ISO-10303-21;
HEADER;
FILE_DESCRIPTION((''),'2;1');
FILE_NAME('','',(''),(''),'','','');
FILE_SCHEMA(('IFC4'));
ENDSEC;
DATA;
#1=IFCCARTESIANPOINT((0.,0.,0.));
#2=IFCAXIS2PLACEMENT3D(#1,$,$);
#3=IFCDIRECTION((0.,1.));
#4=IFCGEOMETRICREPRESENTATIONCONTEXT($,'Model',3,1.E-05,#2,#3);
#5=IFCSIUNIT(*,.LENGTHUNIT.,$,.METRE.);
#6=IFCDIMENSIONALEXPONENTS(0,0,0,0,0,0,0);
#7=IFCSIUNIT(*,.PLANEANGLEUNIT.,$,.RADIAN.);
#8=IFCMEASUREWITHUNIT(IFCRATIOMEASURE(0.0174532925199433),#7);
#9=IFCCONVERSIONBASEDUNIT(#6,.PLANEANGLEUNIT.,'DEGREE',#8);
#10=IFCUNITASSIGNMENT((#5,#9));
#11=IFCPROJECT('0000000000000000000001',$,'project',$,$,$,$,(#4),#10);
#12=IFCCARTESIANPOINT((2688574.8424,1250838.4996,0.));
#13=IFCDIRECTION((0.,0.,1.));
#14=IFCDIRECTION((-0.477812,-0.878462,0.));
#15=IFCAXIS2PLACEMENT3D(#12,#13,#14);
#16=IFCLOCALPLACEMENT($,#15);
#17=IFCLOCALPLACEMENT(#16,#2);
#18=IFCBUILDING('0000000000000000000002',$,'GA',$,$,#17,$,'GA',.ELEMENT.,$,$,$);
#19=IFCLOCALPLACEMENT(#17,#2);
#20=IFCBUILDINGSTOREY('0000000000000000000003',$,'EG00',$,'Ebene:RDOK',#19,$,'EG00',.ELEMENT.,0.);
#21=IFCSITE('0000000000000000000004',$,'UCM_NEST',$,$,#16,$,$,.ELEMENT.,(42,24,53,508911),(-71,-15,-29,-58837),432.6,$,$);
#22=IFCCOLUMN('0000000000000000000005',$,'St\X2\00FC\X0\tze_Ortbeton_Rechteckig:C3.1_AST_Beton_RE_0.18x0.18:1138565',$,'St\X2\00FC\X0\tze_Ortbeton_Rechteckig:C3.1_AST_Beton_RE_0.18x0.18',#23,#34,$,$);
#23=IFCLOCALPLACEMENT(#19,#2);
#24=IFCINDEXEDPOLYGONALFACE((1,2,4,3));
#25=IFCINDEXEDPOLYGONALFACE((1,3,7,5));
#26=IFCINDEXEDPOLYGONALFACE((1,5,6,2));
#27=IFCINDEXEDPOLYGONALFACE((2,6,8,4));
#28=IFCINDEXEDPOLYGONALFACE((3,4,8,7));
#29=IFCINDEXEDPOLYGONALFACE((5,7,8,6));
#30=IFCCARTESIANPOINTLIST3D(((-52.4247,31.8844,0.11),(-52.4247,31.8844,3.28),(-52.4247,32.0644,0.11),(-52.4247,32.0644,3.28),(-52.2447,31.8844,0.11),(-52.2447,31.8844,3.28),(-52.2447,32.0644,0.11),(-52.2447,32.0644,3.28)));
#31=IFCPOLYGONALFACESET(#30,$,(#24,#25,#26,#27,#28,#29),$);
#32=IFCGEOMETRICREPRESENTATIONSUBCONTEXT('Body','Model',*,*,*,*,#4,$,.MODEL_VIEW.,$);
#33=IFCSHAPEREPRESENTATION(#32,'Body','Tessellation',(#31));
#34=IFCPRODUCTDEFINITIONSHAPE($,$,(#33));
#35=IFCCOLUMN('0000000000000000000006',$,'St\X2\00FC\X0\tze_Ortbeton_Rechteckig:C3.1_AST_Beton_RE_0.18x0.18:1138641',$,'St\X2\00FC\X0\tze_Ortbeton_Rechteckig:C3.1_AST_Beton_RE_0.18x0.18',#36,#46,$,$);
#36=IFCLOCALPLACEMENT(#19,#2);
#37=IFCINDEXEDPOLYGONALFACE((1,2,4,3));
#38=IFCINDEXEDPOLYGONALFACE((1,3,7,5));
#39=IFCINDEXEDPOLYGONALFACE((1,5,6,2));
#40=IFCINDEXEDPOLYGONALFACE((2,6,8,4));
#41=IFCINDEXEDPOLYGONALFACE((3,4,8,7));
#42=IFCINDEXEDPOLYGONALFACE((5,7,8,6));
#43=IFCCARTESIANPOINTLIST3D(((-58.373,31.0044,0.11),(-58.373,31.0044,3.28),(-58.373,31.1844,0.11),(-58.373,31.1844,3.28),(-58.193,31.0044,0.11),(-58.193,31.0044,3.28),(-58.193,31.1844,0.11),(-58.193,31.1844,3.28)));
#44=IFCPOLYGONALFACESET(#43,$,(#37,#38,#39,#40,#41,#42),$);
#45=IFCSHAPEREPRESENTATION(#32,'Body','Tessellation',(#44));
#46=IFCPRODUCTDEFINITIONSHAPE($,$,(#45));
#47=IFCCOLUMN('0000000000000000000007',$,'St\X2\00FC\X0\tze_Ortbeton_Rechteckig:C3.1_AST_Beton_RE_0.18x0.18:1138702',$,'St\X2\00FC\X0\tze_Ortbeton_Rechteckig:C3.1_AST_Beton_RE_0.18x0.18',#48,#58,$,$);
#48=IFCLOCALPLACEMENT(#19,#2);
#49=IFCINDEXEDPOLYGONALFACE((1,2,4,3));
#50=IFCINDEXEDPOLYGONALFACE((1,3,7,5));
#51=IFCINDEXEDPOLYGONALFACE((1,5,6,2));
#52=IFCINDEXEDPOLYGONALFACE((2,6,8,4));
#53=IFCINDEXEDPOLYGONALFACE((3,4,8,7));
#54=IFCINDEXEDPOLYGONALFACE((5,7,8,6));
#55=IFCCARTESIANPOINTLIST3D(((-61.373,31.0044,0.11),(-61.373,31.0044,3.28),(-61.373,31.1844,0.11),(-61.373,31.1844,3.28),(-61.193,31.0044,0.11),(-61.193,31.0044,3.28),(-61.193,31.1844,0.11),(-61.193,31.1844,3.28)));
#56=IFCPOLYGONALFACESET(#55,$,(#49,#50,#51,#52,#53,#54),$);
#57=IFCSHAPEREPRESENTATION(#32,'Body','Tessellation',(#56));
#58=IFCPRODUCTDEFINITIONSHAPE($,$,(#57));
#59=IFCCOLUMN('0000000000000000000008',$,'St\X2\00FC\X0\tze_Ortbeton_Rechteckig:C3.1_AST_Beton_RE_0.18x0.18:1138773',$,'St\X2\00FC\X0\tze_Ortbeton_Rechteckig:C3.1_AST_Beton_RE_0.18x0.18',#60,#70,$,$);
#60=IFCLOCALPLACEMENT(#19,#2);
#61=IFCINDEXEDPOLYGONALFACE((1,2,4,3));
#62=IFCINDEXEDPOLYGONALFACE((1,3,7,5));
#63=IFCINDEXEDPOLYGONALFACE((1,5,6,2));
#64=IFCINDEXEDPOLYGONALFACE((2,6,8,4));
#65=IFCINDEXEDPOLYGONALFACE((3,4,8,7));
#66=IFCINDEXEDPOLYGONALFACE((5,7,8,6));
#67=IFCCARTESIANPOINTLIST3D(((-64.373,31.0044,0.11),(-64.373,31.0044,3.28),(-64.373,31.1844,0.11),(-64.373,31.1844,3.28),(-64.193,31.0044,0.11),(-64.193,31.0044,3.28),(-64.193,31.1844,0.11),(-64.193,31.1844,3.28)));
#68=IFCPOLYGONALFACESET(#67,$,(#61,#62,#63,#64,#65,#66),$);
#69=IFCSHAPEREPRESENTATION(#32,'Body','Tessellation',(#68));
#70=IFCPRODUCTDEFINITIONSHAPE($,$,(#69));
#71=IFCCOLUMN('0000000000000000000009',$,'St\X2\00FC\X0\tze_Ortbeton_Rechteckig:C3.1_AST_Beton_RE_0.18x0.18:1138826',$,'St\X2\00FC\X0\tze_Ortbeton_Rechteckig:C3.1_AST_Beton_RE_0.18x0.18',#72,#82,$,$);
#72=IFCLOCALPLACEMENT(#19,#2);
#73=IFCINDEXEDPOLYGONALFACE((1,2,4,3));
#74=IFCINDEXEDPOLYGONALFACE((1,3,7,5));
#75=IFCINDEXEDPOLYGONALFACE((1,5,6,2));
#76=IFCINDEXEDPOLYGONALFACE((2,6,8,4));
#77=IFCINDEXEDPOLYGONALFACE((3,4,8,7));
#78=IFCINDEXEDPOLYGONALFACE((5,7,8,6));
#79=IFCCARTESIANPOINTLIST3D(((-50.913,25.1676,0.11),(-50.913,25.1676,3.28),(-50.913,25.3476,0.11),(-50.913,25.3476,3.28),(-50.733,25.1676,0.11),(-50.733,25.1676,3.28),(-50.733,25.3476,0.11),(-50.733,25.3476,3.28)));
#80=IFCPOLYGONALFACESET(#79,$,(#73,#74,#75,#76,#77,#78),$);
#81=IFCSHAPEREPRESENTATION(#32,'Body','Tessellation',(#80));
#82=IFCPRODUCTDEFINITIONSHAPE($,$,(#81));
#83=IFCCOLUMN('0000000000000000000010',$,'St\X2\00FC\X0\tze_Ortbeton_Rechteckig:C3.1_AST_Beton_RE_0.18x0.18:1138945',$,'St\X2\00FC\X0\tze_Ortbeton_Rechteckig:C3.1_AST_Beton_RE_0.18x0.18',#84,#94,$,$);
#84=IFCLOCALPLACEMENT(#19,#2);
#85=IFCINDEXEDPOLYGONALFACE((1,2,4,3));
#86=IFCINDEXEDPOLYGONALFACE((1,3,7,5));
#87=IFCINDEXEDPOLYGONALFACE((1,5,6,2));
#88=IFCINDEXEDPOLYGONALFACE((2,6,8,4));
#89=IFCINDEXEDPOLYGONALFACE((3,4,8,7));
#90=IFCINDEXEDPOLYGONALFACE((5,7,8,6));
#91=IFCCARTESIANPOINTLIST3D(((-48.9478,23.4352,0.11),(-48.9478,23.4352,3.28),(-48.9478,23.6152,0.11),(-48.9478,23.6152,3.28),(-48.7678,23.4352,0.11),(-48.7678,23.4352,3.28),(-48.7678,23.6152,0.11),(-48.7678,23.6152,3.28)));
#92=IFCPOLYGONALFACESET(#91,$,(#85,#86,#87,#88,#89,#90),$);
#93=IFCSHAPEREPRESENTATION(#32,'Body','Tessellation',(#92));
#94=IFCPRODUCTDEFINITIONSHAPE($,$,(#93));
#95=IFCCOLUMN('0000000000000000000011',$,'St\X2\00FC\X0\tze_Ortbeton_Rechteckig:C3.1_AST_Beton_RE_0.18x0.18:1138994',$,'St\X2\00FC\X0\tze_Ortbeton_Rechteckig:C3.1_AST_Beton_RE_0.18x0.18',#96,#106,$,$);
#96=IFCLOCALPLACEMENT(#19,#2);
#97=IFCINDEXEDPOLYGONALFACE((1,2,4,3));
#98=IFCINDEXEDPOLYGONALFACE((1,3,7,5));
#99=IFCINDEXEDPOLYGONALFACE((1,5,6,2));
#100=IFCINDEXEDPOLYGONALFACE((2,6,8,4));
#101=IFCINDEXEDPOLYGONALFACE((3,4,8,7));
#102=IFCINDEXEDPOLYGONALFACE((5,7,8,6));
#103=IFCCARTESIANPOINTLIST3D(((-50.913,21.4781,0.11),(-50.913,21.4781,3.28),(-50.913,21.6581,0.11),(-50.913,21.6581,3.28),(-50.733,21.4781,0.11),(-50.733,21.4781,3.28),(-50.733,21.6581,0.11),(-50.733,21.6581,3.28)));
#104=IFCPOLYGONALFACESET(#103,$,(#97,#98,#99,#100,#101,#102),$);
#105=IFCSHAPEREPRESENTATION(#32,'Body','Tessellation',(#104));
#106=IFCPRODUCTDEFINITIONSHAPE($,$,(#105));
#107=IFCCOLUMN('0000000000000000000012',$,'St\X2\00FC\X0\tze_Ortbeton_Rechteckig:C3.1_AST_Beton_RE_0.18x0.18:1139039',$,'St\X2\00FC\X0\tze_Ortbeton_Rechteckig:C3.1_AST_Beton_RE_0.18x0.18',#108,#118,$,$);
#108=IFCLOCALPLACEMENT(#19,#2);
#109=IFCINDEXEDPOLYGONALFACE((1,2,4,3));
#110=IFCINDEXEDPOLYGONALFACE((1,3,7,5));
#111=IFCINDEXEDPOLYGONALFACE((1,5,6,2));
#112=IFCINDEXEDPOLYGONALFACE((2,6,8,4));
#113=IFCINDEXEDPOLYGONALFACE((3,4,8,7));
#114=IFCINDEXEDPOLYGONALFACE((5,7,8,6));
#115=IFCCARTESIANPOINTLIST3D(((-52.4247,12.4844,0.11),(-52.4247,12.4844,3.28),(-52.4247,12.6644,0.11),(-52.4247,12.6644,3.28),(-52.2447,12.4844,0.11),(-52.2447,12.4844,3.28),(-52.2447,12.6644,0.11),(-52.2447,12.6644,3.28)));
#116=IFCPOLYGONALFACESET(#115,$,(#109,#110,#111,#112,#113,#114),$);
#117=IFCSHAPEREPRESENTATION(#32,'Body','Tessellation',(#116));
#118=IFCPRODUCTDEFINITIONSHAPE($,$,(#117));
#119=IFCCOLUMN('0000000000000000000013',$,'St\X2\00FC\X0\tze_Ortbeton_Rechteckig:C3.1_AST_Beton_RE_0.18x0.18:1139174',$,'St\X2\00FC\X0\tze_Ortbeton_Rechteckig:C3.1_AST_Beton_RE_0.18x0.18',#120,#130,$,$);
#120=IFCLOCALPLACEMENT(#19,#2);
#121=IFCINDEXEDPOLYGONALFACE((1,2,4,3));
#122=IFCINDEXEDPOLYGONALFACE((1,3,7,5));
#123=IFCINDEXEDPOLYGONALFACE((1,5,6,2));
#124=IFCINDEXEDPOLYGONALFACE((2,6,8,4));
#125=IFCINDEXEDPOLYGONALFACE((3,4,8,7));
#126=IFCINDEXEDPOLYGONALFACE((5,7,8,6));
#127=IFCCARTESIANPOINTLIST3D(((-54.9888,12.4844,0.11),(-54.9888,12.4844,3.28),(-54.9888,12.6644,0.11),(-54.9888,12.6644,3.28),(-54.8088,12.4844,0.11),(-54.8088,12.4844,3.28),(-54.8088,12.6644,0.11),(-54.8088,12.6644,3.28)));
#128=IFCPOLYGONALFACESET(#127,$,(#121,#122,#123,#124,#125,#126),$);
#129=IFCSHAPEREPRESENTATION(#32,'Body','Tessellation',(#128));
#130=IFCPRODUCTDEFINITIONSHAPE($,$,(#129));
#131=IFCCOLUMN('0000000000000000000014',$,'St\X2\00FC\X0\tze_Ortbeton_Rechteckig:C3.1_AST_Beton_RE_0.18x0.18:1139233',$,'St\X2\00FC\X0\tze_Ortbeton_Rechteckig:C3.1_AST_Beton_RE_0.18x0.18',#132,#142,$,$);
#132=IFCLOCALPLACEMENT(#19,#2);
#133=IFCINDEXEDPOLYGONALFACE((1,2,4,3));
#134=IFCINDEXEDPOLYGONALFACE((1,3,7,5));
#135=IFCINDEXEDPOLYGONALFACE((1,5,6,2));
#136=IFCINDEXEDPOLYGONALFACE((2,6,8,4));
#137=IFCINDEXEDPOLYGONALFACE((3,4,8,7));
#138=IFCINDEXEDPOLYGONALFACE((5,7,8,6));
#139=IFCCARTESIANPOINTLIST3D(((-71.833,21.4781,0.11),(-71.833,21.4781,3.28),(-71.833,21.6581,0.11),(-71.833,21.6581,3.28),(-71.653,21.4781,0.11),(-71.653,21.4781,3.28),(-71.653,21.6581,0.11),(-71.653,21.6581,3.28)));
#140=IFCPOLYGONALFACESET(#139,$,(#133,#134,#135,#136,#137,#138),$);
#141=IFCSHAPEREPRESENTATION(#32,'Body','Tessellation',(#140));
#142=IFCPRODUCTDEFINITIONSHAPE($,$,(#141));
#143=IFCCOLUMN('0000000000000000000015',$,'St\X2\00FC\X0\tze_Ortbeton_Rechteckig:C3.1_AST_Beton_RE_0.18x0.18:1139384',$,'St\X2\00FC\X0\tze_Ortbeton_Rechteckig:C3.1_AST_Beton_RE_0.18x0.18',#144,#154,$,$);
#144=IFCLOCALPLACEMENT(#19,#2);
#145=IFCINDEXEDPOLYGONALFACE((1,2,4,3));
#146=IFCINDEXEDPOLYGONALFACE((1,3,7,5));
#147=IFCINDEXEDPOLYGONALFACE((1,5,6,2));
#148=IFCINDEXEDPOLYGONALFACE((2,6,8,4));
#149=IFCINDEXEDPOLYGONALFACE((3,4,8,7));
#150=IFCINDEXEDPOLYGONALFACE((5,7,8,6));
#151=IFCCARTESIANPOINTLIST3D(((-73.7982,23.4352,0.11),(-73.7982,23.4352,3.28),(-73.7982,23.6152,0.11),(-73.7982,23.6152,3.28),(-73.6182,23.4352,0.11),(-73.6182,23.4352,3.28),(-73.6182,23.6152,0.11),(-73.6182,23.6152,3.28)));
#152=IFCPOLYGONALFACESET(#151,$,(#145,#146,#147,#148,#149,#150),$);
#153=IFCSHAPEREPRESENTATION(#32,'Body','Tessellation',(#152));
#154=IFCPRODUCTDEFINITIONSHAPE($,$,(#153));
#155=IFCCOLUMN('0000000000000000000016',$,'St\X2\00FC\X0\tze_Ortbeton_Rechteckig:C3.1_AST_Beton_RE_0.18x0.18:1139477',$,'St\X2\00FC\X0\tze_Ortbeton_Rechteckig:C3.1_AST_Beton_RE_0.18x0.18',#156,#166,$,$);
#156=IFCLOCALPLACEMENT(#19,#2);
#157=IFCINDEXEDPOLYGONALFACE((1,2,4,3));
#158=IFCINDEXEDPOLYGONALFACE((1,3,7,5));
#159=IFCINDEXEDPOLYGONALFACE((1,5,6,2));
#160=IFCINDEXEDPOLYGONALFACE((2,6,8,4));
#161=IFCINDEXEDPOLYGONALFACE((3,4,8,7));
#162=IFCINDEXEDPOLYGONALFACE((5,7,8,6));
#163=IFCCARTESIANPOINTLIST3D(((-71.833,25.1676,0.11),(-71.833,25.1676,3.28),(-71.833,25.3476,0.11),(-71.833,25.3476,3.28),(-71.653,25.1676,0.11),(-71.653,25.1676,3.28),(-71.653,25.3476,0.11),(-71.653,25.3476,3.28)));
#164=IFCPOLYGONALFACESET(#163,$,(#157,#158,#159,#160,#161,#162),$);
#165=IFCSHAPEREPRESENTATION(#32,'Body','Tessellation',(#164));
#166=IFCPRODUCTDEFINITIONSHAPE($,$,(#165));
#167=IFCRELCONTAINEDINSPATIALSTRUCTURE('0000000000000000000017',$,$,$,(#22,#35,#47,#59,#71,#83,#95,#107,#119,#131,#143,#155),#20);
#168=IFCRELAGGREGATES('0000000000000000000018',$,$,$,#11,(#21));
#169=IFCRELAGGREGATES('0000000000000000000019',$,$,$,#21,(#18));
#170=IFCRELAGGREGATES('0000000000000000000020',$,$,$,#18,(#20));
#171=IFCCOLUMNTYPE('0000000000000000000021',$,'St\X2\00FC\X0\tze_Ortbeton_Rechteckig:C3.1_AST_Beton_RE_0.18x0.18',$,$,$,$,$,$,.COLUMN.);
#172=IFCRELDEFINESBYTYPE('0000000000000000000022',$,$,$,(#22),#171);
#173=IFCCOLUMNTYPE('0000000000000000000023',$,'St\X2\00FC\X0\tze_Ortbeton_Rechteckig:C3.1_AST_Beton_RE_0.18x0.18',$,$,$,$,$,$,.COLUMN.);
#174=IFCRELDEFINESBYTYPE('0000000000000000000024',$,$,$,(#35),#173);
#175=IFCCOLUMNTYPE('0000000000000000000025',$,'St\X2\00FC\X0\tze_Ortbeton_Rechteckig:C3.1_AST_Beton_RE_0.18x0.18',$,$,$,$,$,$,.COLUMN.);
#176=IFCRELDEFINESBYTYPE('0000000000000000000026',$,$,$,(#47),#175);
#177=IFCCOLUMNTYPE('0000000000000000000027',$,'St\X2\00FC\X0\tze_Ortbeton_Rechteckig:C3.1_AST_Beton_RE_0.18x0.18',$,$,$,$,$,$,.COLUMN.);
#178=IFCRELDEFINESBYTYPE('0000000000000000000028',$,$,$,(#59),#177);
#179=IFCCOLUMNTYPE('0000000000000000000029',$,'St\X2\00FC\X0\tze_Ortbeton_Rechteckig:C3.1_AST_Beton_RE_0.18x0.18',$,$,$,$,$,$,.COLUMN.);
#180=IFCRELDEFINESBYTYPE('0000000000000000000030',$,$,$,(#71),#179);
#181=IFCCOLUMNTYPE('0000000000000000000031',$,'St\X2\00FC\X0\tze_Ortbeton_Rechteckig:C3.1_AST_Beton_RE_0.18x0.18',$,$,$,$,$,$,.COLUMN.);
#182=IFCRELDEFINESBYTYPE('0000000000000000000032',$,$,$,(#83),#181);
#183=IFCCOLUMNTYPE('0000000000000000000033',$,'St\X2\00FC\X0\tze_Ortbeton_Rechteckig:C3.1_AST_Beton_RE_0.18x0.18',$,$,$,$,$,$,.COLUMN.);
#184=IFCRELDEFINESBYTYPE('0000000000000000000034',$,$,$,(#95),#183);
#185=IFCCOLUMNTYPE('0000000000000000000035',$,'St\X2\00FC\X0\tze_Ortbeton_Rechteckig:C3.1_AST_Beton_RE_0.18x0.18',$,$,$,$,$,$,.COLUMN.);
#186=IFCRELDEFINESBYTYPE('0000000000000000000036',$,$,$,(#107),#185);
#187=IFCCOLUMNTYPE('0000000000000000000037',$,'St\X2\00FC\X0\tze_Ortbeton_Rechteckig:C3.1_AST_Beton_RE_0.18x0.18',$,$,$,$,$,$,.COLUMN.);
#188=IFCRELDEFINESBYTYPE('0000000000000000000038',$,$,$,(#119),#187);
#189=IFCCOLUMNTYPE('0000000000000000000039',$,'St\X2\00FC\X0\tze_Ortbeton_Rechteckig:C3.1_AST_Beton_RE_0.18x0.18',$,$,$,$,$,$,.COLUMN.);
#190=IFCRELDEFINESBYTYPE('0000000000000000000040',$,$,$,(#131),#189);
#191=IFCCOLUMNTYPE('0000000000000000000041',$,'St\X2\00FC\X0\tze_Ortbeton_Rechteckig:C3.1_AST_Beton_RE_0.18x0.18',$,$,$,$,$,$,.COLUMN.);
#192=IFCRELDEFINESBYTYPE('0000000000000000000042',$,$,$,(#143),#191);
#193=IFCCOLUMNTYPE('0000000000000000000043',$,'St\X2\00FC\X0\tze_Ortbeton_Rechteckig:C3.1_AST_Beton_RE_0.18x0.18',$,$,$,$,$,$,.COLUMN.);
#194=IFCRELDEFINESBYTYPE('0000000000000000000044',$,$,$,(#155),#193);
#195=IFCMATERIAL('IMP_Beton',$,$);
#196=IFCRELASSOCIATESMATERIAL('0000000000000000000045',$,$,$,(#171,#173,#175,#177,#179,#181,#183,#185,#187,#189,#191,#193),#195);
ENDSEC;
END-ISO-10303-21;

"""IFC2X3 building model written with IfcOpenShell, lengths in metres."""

from ifc_helpers import new_model, entity, si_unit, converted_unit, direction, frame, frame_2d, origin, origin_2d_with_axis, place, context, subcontext, project, spatial, rectangle, extrude, source, transform, mapped, material, type_object, type_shapes, element, save


model = new_model("IFC2X3")

# Units and contexts
model_context = context("Model", 3, precision=1e-05, world=origin(), true_north=direction((0.0, 1.0)))
body_context = subcontext(model_context, "Body", "Model", "MODEL_VIEW")
ifc_project = project(units=[si_unit("LENGTHUNIT", "METRE"), converted_unit("PLANEANGLEUNIT", "DEGREE", entity("IfcRatioMeasure", 0.0174532925199433), si_unit("PLANEANGLEUNIT", "RADIAN"), dimensions=[0, 0, 0, 0, 0, 0, 0])], contexts=[model_context])

# Site, building, storey
site_placement = place(None, frame((2688574.8424, 1250838.4996, 0.0), z_axis=(0.0, 0.0, 1.0), x_axis=(-0.477812, -0.878462, 0.0)))
site = spatial("IfcSite", under=ifc_project, at=site_placement, Name="UCM_NEST", CompositionType="ELEMENT", RefLatitude=(42, 24, 53, 508911), RefLongitude=(-71, -15, -29, -58837), RefElevation=432.6)
building_placement = place(site_placement, origin())
building = spatial("IfcBuilding", under=site, at=building_placement, Name="GA", LongName="GA", CompositionType="ELEMENT")
storey_placement = place(building_placement, origin())
storey = spatial("IfcBuildingStorey", under=building, at=storey_placement, Name="EG00", ObjectType="Ebene:RDOK", LongName="EG00", CompositionType="ELEMENT", Elevation=0.0)

# Columns
ifc_material_1 = material(Name="IMP_Beton")
column_type_1 = type_object("IfcColumnType", Name="Stütze_Ortbeton_Rechteckig:C3.1_AST_Beton_RE_0.18x0.18", PredefinedType="COLUMN", material=ifc_material_1)
shared_shape_1 = source(origin(), body_context, "Body", "SweptSolid", [
    extrude(rectangle(XDim=0.18, YDim=0.18, at=origin_2d_with_axis()), frame((-52.3347, 31.9744, 0.11), z_axis=(0.0, 0.0, 1.0), x_axis=(0.0, -1.0, 0.0)), (0.0, 0.0, 1.0), 3.17),
])
type_shapes(column_type_1, [shared_shape_1])
column_1_placement = place(storey_placement, origin())
element("IfcColumn", 1, at=column_1_placement, inside=storey, type_object=column_type_1, Name="Stütze_Ortbeton_Rechteckig:C3.1_AST_Beton_RE_0.18x0.18:1138565", ObjectType="Stütze_Ortbeton_Rechteckig:C3.1_AST_Beton_RE_0.18x0.18", context=body_context, shape_type="MappedRepresentation", body=[
    mapped(shared_shape_1, transform((0.0, 0.0, 0.0), scale=1.0)),
])
column_type_2 = type_object("IfcColumnType", Name="Stütze_Ortbeton_Rechteckig:C3.1_AST_Beton_RE_0.18x0.18", PredefinedType="COLUMN", material=ifc_material_1)
shared_shape_2 = source(origin(), body_context, "Body", "SweptSolid", [
    extrude(rectangle(XDim=0.18, YDim=0.18, at=frame_2d((0.0, 0.0), x_axis=(1.0, 0.0))), frame((-58.283, 31.0944, 0.11), z_axis=(0.0, 0.0, 1.0), x_axis=(0.0, -1.0, 0.0)), (0.0, 0.0, 1.0), 3.17),
])
type_shapes(column_type_2, [shared_shape_2])
column_2_placement = place(storey_placement, origin())
element("IfcColumn", 2, at=column_2_placement, inside=storey, type_object=column_type_2, Name="Stütze_Ortbeton_Rechteckig:C3.1_AST_Beton_RE_0.18x0.18:1138641", ObjectType="Stütze_Ortbeton_Rechteckig:C3.1_AST_Beton_RE_0.18x0.18", context=body_context, shape_type="MappedRepresentation", body=[
    mapped(shared_shape_2, transform((0.0, 0.0, 0.0), scale=1.0)),
])
column_type_3 = type_object("IfcColumnType", Name="Stütze_Ortbeton_Rechteckig:C3.1_AST_Beton_RE_0.18x0.18", PredefinedType="COLUMN", material=ifc_material_1)
shared_shape_3 = source(origin(), body_context, "Body", "SweptSolid", [
    extrude(rectangle(XDim=0.18, YDim=0.18, at=frame_2d((0.0, 0.0), x_axis=(1.0, 0.0))), frame((-61.283, 31.0944, 0.11), z_axis=(0.0, 0.0, 1.0), x_axis=(0.0, -1.0, 0.0)), (0.0, 0.0, 1.0), 3.17),
])
type_shapes(column_type_3, [shared_shape_3])
column_3_placement = place(storey_placement, origin())
element("IfcColumn", 3, at=column_3_placement, inside=storey, type_object=column_type_3, Name="Stütze_Ortbeton_Rechteckig:C3.1_AST_Beton_RE_0.18x0.18:1138702", ObjectType="Stütze_Ortbeton_Rechteckig:C3.1_AST_Beton_RE_0.18x0.18", context=body_context, shape_type="MappedRepresentation", body=[
    mapped(shared_shape_3, transform((0.0, 0.0, 0.0), scale=1.0)),
])
column_type_4 = type_object("IfcColumnType", Name="Stütze_Ortbeton_Rechteckig:C3.1_AST_Beton_RE_0.18x0.18", PredefinedType="COLUMN", material=ifc_material_1)
shared_shape_4 = source(origin(), body_context, "Body", "SweptSolid", [
    extrude(rectangle(XDim=0.18, YDim=0.18, at=frame_2d((0.0, 0.0), x_axis=(1.0, 0.0))), frame((-64.283, 31.0944, 0.11), z_axis=(0.0, 0.0, 1.0), x_axis=(0.0, -1.0, 0.0)), (0.0, 0.0, 1.0), 3.17),
])
type_shapes(column_type_4, [shared_shape_4])
column_4_placement = place(storey_placement, origin())
element("IfcColumn", 4, at=column_4_placement, inside=storey, type_object=column_type_4, Name="Stütze_Ortbeton_Rechteckig:C3.1_AST_Beton_RE_0.18x0.18:1138773", ObjectType="Stütze_Ortbeton_Rechteckig:C3.1_AST_Beton_RE_0.18x0.18", context=body_context, shape_type="MappedRepresentation", body=[
    mapped(shared_shape_4, transform((0.0, 0.0, 0.0), scale=1.0)),
])
column_type_5 = type_object("IfcColumnType", Name="Stütze_Ortbeton_Rechteckig:C3.1_AST_Beton_RE_0.18x0.18", PredefinedType="COLUMN", material=ifc_material_1)
shared_shape_5 = source(origin(), body_context, "Body", "SweptSolid", [
    extrude(rectangle(XDim=0.18, YDim=0.18, at=origin_2d_with_axis()), frame((-50.823, 25.2576, 0.11), z_axis=(0.0, 0.0, 1.0), x_axis=(0.0, -1.0, 0.0)), (0.0, 0.0, 1.0), 3.17),
])
type_shapes(column_type_5, [shared_shape_5])
column_5_placement = place(storey_placement, origin())
element("IfcColumn", 5, at=column_5_placement, inside=storey, type_object=column_type_5, Name="Stütze_Ortbeton_Rechteckig:C3.1_AST_Beton_RE_0.18x0.18:1138826", ObjectType="Stütze_Ortbeton_Rechteckig:C3.1_AST_Beton_RE_0.18x0.18", context=body_context, shape_type="MappedRepresentation", body=[
    mapped(shared_shape_5, transform((0.0, 0.0, 0.0), scale=1.0)),
])
column_type_6 = type_object("IfcColumnType", Name="Stütze_Ortbeton_Rechteckig:C3.1_AST_Beton_RE_0.18x0.18", PredefinedType="COLUMN", material=ifc_material_1)
shared_shape_6 = source(origin(), body_context, "Body", "SweptSolid", [
    extrude(rectangle(XDim=0.18, YDim=0.18, at=origin_2d_with_axis()), frame((-48.8578, 23.5252, 0.11), z_axis=(0.0, 0.0, 1.0), x_axis=(0.0, -1.0, 0.0)), (0.0, 0.0, 1.0), 3.17),
])
type_shapes(column_type_6, [shared_shape_6])
column_6_placement = place(storey_placement, origin())
element("IfcColumn", 6, at=column_6_placement, inside=storey, type_object=column_type_6, Name="Stütze_Ortbeton_Rechteckig:C3.1_AST_Beton_RE_0.18x0.18:1138945", ObjectType="Stütze_Ortbeton_Rechteckig:C3.1_AST_Beton_RE_0.18x0.18", context=body_context, shape_type="MappedRepresentation", body=[
    mapped(shared_shape_6, transform((0.0, 0.0, 0.0), scale=1.0)),
])
column_type_7 = type_object("IfcColumnType", Name="Stütze_Ortbeton_Rechteckig:C3.1_AST_Beton_RE_0.18x0.18", PredefinedType="COLUMN", material=ifc_material_1)
shared_shape_7 = source(origin(), body_context, "Body", "SweptSolid", [
    extrude(rectangle(XDim=0.18, YDim=0.18, at=origin_2d_with_axis()), frame((-50.823, 21.5681, 0.11), z_axis=(0.0, 0.0, 1.0), x_axis=(0.0, -1.0, 0.0)), (0.0, 0.0, 1.0), 3.17),
])
type_shapes(column_type_7, [shared_shape_7])
column_7_placement = place(storey_placement, origin())
element("IfcColumn", 7, at=column_7_placement, inside=storey, type_object=column_type_7, Name="Stütze_Ortbeton_Rechteckig:C3.1_AST_Beton_RE_0.18x0.18:1138994", ObjectType="Stütze_Ortbeton_Rechteckig:C3.1_AST_Beton_RE_0.18x0.18", context=body_context, shape_type="MappedRepresentation", body=[
    mapped(shared_shape_7, transform((0.0, 0.0, 0.0), scale=1.0)),
])
column_type_8 = type_object("IfcColumnType", Name="Stütze_Ortbeton_Rechteckig:C3.1_AST_Beton_RE_0.18x0.18", PredefinedType="COLUMN", material=ifc_material_1)
shared_shape_8 = source(origin(), body_context, "Body", "SweptSolid", [
    extrude(rectangle(XDim=0.18, YDim=0.18, at=origin_2d_with_axis()), frame((-52.3347, 12.5744, 0.11), z_axis=(0.0, 0.0, 1.0), x_axis=(0.0, -1.0, 0.0)), (0.0, 0.0, 1.0), 3.17),
])
type_shapes(column_type_8, [shared_shape_8])
column_8_placement = place(storey_placement, origin())
element("IfcColumn", 8, at=column_8_placement, inside=storey, type_object=column_type_8, Name="Stütze_Ortbeton_Rechteckig:C3.1_AST_Beton_RE_0.18x0.18:1139039", ObjectType="Stütze_Ortbeton_Rechteckig:C3.1_AST_Beton_RE_0.18x0.18", context=body_context, shape_type="MappedRepresentation", body=[
    mapped(shared_shape_8, transform((0.0, 0.0, 0.0), scale=1.0)),
])
column_type_9 = type_object("IfcColumnType", Name="Stütze_Ortbeton_Rechteckig:C3.1_AST_Beton_RE_0.18x0.18", PredefinedType="COLUMN", material=ifc_material_1)
shared_shape_9 = source(origin(), body_context, "Body", "SweptSolid", [
    extrude(rectangle(XDim=0.18, YDim=0.18, at=origin_2d_with_axis()), frame((-54.8988, 12.5744, 0.11), z_axis=(0.0, 0.0, 1.0), x_axis=(0.0, -1.0, 0.0)), (0.0, 0.0, 1.0), 3.17),
])
type_shapes(column_type_9, [shared_shape_9])
column_9_placement = place(storey_placement, origin())
element("IfcColumn", 9, at=column_9_placement, inside=storey, type_object=column_type_9, Name="Stütze_Ortbeton_Rechteckig:C3.1_AST_Beton_RE_0.18x0.18:1139174", ObjectType="Stütze_Ortbeton_Rechteckig:C3.1_AST_Beton_RE_0.18x0.18", context=body_context, shape_type="MappedRepresentation", body=[
    mapped(shared_shape_9, transform((0.0, 0.0, 0.0), scale=1.0)),
])
column_type_10 = type_object("IfcColumnType", Name="Stütze_Ortbeton_Rechteckig:C3.1_AST_Beton_RE_0.18x0.18", PredefinedType="COLUMN", material=ifc_material_1)
shared_shape_10 = source(origin(), body_context, "Body", "SweptSolid", [
    extrude(rectangle(XDim=0.18, YDim=0.18, at=origin_2d_with_axis()), frame((-71.743, 21.5681, 0.11), z_axis=(0.0, 0.0, 1.0), x_axis=(0.0, -1.0, 0.0)), (0.0, 0.0, 1.0), 3.17),
])
type_shapes(column_type_10, [shared_shape_10])
column_10_placement = place(storey_placement, origin())
element("IfcColumn", 10, at=column_10_placement, inside=storey, type_object=column_type_10, Name="Stütze_Ortbeton_Rechteckig:C3.1_AST_Beton_RE_0.18x0.18:1139233", ObjectType="Stütze_Ortbeton_Rechteckig:C3.1_AST_Beton_RE_0.18x0.18", context=body_context, shape_type="MappedRepresentation", body=[
    mapped(shared_shape_10, transform((0.0, 0.0, 0.0), scale=1.0)),
])
column_type_11 = type_object("IfcColumnType", Name="Stütze_Ortbeton_Rechteckig:C3.1_AST_Beton_RE_0.18x0.18", PredefinedType="COLUMN", material=ifc_material_1)
shared_shape_11 = source(origin(), body_context, "Body", "SweptSolid", [
    extrude(rectangle(XDim=0.18, YDim=0.18, at=origin_2d_with_axis()), frame((-73.7082, 23.5252, 0.11), z_axis=(0.0, 0.0, 1.0), x_axis=(0.0, -1.0, 0.0)), (0.0, 0.0, 1.0), 3.17),
])
type_shapes(column_type_11, [shared_shape_11])
column_11_placement = place(storey_placement, origin())
element("IfcColumn", 11, at=column_11_placement, inside=storey, type_object=column_type_11, Name="Stütze_Ortbeton_Rechteckig:C3.1_AST_Beton_RE_0.18x0.18:1139384", ObjectType="Stütze_Ortbeton_Rechteckig:C3.1_AST_Beton_RE_0.18x0.18", context=body_context, shape_type="MappedRepresentation", body=[
    mapped(shared_shape_11, transform((0.0, 0.0, 0.0), scale=1.0)),
])
column_type_12 = type_object("IfcColumnType", Name="Stütze_Ortbeton_Rechteckig:C3.1_AST_Beton_RE_0.18x0.18", PredefinedType="COLUMN", material=ifc_material_1)
shared_shape_12 = source(origin(), body_context, "Body", "SweptSolid", [
    extrude(rectangle(XDim=0.18, YDim=0.18, at=origin_2d_with_axis()), frame((-71.743, 25.2576, 0.11), z_axis=(0.0, 0.0, 1.0), x_axis=(0.0, -1.0, 0.0)), (0.0, 0.0, 1.0), 3.17),
])
type_shapes(column_type_12, [shared_shape_12])
column_12_placement = place(storey_placement, origin())
element("IfcColumn", 12, at=column_12_placement, inside=storey, type_object=column_type_12, Name="Stütze_Ortbeton_Rechteckig:C3.1_AST_Beton_RE_0.18x0.18:1139477", ObjectType="Stütze_Ortbeton_Rechteckig:C3.1_AST_Beton_RE_0.18x0.18", context=body_context, shape_type="MappedRepresentation", body=[
    mapped(shared_shape_12, transform((0.0, 0.0, 0.0), scale=1.0)),
])

save(model, "model.ifc")
